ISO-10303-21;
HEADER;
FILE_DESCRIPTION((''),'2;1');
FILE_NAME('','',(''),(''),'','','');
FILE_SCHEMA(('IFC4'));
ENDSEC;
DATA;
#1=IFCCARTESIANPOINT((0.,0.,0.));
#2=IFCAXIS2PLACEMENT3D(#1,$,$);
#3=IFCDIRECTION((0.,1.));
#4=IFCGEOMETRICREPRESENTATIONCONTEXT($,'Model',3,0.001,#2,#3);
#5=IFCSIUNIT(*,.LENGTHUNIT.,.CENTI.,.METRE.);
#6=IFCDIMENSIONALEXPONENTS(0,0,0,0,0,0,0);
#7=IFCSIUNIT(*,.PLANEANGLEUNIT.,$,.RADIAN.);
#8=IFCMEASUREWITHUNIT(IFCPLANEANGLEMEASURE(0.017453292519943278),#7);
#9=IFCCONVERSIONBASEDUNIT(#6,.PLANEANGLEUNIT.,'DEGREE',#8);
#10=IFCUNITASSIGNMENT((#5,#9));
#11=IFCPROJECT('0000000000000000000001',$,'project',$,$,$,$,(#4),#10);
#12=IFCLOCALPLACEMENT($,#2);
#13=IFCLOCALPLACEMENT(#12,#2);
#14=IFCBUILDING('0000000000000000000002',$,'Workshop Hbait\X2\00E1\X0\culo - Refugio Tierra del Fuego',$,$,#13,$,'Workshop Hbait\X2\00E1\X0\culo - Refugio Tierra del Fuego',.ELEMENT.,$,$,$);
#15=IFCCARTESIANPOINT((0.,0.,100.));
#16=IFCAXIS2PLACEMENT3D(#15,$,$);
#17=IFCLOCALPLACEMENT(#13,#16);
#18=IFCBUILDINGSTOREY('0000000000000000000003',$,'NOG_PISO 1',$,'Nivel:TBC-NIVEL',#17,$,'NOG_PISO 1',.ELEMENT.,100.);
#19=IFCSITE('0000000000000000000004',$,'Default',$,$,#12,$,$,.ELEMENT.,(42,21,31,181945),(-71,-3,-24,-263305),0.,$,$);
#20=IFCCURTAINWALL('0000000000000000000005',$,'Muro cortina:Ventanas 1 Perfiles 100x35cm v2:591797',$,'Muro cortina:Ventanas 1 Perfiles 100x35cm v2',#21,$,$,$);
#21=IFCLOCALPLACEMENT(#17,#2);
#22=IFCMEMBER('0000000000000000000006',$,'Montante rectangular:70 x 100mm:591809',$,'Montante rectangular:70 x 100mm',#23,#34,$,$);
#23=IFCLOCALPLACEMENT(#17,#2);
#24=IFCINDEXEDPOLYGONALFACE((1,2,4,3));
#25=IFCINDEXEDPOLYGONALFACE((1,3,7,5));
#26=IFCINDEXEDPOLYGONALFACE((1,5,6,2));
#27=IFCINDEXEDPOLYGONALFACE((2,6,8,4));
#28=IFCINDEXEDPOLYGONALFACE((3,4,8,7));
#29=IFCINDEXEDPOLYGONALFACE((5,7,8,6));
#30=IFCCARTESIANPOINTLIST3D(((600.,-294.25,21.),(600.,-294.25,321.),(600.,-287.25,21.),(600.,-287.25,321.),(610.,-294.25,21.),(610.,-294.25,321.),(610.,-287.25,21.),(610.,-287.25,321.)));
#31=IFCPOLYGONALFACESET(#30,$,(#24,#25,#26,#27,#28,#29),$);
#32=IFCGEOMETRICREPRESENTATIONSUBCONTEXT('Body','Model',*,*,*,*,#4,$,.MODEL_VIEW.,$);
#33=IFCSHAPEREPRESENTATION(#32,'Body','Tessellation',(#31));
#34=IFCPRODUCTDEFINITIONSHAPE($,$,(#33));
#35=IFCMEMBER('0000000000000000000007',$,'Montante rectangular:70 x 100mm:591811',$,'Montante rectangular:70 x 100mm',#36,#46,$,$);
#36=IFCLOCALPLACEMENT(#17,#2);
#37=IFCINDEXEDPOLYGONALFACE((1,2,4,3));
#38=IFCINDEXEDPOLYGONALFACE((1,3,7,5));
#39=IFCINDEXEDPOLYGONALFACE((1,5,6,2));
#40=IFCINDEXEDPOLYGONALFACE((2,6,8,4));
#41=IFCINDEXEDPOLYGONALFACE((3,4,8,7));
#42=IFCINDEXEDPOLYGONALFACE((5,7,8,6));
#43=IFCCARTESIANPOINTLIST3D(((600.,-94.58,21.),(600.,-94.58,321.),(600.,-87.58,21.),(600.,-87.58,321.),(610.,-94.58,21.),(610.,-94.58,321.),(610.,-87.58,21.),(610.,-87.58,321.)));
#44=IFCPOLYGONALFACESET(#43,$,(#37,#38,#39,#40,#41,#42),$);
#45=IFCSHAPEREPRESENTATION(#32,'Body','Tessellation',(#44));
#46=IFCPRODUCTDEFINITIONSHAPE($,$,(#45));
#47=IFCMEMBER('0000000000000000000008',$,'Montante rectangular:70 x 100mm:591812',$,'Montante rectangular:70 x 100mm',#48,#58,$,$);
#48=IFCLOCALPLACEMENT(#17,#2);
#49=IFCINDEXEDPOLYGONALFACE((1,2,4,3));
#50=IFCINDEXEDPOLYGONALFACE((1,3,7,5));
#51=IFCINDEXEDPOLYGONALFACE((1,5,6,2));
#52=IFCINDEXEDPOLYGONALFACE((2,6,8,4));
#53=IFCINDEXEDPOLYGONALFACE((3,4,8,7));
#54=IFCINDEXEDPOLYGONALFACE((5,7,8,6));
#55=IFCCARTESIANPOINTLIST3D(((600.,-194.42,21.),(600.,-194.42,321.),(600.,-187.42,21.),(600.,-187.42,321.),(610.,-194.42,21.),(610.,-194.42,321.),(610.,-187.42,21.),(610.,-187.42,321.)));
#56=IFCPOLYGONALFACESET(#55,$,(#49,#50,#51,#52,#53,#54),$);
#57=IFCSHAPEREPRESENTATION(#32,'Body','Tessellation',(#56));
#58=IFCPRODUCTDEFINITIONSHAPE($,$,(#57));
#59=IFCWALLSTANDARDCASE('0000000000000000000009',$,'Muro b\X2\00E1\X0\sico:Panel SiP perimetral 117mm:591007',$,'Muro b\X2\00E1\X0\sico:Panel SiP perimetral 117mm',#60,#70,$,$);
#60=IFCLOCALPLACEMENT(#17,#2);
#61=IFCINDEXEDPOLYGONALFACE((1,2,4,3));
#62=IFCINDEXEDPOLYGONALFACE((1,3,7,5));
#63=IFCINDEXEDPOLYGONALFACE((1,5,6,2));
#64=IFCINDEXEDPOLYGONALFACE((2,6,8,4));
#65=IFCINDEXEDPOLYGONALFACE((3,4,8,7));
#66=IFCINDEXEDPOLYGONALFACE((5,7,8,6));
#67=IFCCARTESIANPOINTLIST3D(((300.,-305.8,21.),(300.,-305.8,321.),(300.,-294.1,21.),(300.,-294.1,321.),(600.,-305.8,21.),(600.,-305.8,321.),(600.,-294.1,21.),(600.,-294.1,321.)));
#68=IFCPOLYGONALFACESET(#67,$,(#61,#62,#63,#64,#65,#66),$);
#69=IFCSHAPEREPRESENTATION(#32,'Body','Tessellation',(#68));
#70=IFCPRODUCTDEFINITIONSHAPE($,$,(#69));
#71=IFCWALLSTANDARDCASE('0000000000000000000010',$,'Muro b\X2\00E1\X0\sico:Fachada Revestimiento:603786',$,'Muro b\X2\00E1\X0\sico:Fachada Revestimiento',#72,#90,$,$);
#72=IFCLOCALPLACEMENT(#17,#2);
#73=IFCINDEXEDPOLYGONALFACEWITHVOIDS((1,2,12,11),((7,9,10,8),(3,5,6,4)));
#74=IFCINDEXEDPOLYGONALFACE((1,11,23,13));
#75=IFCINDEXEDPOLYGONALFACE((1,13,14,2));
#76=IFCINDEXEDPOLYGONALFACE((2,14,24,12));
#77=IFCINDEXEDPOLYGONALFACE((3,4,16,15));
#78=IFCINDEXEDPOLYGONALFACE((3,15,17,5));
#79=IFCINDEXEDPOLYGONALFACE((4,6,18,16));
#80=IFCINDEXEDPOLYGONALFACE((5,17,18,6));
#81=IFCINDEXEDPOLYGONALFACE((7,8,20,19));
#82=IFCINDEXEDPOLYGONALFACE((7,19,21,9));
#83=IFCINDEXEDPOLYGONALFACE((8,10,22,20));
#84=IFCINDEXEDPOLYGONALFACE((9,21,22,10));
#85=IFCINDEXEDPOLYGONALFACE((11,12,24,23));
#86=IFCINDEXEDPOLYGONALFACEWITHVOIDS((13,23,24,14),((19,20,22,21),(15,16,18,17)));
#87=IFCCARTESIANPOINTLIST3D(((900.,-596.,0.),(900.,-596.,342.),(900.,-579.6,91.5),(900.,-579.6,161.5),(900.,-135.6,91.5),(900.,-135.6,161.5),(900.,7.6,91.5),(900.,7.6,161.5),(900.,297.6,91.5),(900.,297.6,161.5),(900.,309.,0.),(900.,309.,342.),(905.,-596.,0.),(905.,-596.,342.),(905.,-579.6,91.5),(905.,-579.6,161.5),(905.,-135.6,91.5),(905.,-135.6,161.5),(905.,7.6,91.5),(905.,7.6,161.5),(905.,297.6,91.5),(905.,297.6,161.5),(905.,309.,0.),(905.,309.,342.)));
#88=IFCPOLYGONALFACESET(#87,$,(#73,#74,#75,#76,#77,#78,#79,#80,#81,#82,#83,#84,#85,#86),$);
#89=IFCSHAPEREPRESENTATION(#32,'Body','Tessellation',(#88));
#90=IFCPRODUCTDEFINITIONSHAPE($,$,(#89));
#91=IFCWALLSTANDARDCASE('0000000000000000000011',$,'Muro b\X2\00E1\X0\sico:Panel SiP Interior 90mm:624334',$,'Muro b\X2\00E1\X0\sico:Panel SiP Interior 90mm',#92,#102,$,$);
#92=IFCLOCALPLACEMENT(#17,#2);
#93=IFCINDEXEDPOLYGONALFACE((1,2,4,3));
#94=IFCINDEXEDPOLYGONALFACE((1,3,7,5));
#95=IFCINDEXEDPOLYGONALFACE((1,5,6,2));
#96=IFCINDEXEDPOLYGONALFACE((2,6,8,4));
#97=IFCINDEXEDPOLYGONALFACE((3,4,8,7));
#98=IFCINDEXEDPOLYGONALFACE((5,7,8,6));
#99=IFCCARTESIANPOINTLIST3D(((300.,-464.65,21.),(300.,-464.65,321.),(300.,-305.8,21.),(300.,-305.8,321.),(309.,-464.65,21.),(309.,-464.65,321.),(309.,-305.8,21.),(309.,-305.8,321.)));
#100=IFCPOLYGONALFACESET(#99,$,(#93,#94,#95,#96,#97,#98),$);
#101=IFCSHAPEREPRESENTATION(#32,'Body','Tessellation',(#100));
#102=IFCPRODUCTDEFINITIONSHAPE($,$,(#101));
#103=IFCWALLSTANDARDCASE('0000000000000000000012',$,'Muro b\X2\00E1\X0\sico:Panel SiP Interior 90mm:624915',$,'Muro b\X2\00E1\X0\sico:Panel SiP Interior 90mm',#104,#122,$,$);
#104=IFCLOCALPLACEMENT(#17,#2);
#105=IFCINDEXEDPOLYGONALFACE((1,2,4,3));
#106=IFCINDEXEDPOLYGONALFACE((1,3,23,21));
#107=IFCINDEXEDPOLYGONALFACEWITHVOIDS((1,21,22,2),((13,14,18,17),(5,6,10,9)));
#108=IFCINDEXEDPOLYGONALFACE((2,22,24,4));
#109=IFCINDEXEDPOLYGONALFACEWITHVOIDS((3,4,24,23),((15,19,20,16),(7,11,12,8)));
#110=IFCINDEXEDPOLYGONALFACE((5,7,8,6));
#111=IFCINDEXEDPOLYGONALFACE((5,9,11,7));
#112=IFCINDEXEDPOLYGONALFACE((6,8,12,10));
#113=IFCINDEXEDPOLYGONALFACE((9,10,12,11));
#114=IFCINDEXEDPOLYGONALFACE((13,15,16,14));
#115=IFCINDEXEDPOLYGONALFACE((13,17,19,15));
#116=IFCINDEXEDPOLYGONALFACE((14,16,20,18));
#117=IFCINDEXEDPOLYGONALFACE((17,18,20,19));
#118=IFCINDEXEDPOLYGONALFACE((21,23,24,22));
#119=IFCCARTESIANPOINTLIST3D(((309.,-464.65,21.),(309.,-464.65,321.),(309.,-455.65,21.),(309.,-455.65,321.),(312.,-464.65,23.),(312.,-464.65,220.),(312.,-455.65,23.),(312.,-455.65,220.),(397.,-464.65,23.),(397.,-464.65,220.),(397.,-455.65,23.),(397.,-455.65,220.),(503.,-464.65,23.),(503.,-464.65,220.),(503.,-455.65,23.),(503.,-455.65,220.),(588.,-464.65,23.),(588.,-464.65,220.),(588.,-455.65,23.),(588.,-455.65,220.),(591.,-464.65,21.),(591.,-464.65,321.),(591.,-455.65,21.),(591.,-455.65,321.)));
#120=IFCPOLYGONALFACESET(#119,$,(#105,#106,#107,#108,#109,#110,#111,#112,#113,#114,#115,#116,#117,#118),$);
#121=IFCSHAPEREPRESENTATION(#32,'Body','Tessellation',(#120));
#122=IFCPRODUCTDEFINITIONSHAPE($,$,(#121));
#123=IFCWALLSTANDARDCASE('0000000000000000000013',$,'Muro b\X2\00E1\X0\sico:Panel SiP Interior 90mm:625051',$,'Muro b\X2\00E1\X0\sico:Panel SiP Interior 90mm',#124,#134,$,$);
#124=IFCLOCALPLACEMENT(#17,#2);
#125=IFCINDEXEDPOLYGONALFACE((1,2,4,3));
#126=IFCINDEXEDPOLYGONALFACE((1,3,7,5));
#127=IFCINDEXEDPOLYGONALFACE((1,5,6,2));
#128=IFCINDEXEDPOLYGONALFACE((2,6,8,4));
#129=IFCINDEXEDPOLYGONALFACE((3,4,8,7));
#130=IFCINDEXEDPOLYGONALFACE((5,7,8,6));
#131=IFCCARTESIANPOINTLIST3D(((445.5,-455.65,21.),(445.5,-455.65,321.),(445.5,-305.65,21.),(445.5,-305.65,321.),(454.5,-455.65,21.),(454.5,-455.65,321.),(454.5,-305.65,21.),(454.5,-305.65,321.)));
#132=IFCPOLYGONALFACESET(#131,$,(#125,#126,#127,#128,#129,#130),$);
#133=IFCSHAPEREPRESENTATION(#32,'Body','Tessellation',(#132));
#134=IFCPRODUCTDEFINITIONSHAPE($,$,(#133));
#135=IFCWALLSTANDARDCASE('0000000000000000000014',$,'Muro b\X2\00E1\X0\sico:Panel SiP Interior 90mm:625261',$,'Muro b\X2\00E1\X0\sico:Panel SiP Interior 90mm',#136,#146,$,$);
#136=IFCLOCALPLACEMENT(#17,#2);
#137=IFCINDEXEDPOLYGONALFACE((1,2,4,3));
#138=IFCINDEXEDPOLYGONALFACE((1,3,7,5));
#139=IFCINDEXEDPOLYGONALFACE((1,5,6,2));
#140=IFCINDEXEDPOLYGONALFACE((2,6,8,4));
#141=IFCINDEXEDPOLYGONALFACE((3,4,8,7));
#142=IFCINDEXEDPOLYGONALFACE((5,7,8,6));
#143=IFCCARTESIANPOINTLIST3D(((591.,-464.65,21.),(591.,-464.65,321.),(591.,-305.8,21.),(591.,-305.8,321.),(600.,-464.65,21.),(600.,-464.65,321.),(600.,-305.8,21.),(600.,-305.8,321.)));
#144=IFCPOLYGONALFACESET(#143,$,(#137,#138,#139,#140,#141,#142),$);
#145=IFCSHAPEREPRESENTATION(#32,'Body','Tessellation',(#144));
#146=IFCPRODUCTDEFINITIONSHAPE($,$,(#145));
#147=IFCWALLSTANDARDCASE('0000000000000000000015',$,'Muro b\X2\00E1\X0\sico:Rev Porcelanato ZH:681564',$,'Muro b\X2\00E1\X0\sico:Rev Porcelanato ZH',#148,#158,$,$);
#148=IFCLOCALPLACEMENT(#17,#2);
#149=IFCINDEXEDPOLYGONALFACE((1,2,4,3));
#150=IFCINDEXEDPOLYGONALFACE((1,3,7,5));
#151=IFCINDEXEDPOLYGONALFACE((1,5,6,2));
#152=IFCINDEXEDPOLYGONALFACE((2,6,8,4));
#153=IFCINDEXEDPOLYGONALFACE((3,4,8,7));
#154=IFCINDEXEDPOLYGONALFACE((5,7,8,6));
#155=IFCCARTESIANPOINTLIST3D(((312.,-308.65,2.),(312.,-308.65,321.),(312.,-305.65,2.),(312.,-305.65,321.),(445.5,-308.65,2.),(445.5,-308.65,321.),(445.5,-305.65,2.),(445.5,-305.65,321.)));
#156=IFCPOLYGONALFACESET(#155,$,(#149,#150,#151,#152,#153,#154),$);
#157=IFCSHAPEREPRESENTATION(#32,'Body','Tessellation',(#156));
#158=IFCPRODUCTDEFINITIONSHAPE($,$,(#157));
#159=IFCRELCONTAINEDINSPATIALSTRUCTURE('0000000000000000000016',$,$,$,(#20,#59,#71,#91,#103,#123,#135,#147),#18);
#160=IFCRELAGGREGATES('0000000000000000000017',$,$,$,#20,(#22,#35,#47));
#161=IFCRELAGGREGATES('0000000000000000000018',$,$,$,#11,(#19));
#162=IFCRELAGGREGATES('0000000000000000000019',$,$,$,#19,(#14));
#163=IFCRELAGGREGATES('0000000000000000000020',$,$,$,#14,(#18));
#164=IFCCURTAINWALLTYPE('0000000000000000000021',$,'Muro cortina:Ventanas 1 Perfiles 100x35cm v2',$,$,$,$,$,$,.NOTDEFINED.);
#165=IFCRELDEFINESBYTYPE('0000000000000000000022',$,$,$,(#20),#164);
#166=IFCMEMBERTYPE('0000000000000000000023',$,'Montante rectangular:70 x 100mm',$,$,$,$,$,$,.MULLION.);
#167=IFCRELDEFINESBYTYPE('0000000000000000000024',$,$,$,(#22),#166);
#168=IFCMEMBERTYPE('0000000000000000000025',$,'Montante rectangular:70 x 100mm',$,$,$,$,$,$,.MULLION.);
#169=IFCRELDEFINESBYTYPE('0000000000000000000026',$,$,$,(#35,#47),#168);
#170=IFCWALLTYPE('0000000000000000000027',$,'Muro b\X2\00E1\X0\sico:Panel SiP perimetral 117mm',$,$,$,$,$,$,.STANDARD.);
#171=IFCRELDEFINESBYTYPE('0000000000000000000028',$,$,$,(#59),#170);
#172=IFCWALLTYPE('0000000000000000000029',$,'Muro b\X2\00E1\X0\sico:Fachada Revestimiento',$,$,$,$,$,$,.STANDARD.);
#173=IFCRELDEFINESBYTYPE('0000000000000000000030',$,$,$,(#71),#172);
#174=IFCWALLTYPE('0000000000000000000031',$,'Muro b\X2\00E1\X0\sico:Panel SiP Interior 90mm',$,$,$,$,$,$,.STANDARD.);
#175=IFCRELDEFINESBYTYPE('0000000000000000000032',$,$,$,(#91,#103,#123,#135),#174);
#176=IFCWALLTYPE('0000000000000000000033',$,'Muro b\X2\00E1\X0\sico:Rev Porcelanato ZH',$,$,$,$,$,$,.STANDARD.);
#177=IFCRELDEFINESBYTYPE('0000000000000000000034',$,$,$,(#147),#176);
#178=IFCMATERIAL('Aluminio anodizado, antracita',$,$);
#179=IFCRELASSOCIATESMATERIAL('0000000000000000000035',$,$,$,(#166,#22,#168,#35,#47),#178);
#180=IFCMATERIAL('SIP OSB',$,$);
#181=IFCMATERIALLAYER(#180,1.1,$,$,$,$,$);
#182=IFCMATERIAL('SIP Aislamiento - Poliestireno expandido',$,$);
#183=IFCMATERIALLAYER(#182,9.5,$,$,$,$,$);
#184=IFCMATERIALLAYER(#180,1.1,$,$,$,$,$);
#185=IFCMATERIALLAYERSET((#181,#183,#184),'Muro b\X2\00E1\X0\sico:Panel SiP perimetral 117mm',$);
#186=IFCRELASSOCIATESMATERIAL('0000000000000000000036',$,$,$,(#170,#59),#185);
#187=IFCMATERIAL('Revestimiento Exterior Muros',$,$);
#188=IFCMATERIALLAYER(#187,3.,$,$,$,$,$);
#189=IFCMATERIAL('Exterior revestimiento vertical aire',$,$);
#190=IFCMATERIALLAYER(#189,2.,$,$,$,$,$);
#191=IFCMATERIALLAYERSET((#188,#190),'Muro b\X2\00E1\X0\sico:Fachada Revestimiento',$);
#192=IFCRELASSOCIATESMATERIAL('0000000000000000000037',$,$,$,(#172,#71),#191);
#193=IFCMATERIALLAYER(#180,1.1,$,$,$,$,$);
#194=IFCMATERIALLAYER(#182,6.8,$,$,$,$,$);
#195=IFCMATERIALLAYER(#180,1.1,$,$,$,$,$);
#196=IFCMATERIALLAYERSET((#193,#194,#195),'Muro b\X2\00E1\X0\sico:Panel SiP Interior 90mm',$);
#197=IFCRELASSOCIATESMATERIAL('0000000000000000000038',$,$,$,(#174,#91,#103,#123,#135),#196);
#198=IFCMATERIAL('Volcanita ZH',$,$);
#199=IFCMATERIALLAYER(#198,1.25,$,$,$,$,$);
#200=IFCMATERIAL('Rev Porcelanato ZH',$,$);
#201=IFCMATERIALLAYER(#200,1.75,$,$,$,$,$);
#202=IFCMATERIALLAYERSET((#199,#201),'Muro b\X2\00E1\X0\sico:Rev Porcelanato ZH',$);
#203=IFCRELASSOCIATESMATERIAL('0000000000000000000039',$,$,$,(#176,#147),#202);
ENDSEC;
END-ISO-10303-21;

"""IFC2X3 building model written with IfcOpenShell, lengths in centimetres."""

from ifc_helpers import new_model, entity, si_unit, converted_unit, direction, frame, frame_2d, origin, origin_2d_with_axis, place, context, subcontext, project, spatial, rectangle, extrude, source, transform, mapped, material, layer, layer_set, layer_usage, type_object, type_shapes, element, aggregate, save


model = new_model("IFC2X3")

# Units and contexts
model_context = context("Model", 3, precision=0.001, world=origin(), true_north=direction((0.0, 1.0)))
body_context = subcontext(model_context, "Body", "Model", "MODEL_VIEW")
ifc_project = project(units=[si_unit("LENGTHUNIT", "METRE", prefix="CENTI"), converted_unit("PLANEANGLEUNIT", "DEGREE", entity("IfcPlaneAngleMeasure", 0.017453292519943278), si_unit("PLANEANGLEUNIT", "RADIAN"), dimensions=[0, 0, 0, 0, 0, 0, 0])], contexts=[model_context])

# Site, building, storey
site_placement = place(None, origin())
site = spatial("IfcSite", under=ifc_project, at=site_placement, Name="Default", CompositionType="ELEMENT", RefLatitude=(42, 21, 31, 181945), RefLongitude=(-71, -3, -24, -263305), RefElevation=0.0)
building_placement = place(site_placement, origin())
building = spatial("IfcBuilding", under=site, at=building_placement, Name="Workshop Hbaitáculo - Refugio Tierra del Fuego", LongName="Workshop Hbaitáculo - Refugio Tierra del Fuego", CompositionType="ELEMENT")
storey_placement = place(building_placement, frame((0.0, 0.0, 100.0)))
storey = spatial("IfcBuildingStorey", under=building, at=storey_placement, Name="NOG_PISO 1", ObjectType="Nivel:TBC-NIVEL", LongName="NOG_PISO 1", CompositionType="ELEMENT", Elevation=100.0)

# Curtain wall, members
curtain_wall_type = type_object("IfcCurtainWallType", Name="Muro cortina:Ventanas 1 Perfiles 100x35cm v2", PredefinedType="NOTDEFINED")
ifc_material_1 = material(Name="Aluminio anodizado, antracita")
curtain_wall_1_placement = place(storey_placement, frame((0.0, 0.0, -100.0)))
curtain_wall_1 = element("IfcCurtainWall", 1, at=curtain_wall_1_placement, inside=storey, type_object=curtain_wall_type, Name="Muro cortina:Ventanas 1 Perfiles 100x35cm v2:591797", ObjectType="Muro cortina:Ventanas 1 Perfiles 100x35cm v2")
member_type_1 = type_object("IfcMemberType", Name="Montante rectangular:70 x 100mm", PredefinedType="MULLION", material=ifc_material_1)
shared_shape_1 = source(origin(), body_context, "Body", "SweptSolid", [
    extrude(rectangle(XDim=7.0, YDim=10.0, at=origin_2d_with_axis()), frame((-3.5, 0.0, -300.0), z_axis=(0.0, 0.0, 1.0), x_axis=(-1.0, 0.0, 0.0)), (0.0, 0.0, 1.0), 300.0),
])
type_shapes(member_type_1, [shared_shape_1])
member_1_placement = place(curtain_wall_1_placement, frame((605.0, -294.25, 121.0), z_axis=(0.0, 0.0, -1.0), x_axis=(0.0, -1.0, 0.0)))
member_1 = element("IfcMember", 2, at=member_1_placement, type_object=member_type_1, material=ifc_material_1, Name="Montante rectangular:70 x 100mm:591809", ObjectType="Montante rectangular:70 x 100mm", context=body_context, shape_type="MappedRepresentation", body=[
    mapped(shared_shape_1, transform((0.0, 0.0, 0.0), scale=1.0)),
])
member_type_2 = type_object("IfcMemberType", Name="Montante rectangular:70 x 100mm", PredefinedType="MULLION", material=ifc_material_1)
shared_shape_2 = source(origin(), body_context, "Body", "SweptSolid", [
    extrude(rectangle(XDim=7.0, YDim=10.0, at=frame_2d((0.0, 0.0), x_axis=(1.0, 0.0))), frame((0.0, 0.0, -300.0), z_axis=(0.0, 0.0, 1.0), x_axis=(-1.0, 0.0, 0.0)), (0.0, 0.0, 1.0), 300.0),
])
type_shapes(member_type_2, [shared_shape_2])
member_2_placement = place(curtain_wall_1_placement, frame((605.0, -91.08, 121.0), z_axis=(0.0, 0.0, -1.0), x_axis=(0.0, -1.0, 0.0)))
member_2 = element("IfcMember", 3, at=member_2_placement, type_object=member_type_2, material=ifc_material_1, Name="Montante rectangular:70 x 100mm:591811", ObjectType="Montante rectangular:70 x 100mm", context=body_context, shape_type="MappedRepresentation", body=[
    mapped(shared_shape_2, transform((0.0, 0.0, 0.0), scale=1.0)),
])
member_3_placement = place(curtain_wall_1_placement, frame((605.0, -190.92, 121.0), z_axis=(0.0, 0.0, -1.0), x_axis=(0.0, -1.0, 0.0)))
member_3 = element("IfcMember", 4, at=member_3_placement, type_object=member_type_2, material=ifc_material_1, Name="Montante rectangular:70 x 100mm:591812", ObjectType="Montante rectangular:70 x 100mm", context=body_context, shape_type="MappedRepresentation", body=[
    mapped(shared_shape_2, transform((0.0, 0.0, 0.0), scale=1.0)),
])

aggregate(curtain_wall_1, [member_1, member_2, member_3])

# Wall
ifc_material_2 = material(Name="SIP OSB")
ifc_layer_1 = layer(ifc_material_2, 1.1)
ifc_material_3 = material(Name="SIP Aislamiento - Poliestireno expandido")
ifc_layer_2 = layer(ifc_material_3, 9.5)
ifc_layer_3 = layer(ifc_material_2, 1.1)
ifc_layer_set_1 = layer_set([ifc_layer_1, ifc_layer_2, ifc_layer_3], Name="Muro básico:Panel SiP perimetral 117mm")
ifc_layer_usage_1 = layer_usage(ifc_layer_set_1, "AXIS2", "POSITIVE", -5.85)
wall_type_1 = type_object("IfcWallType", Name="Muro básico:Panel SiP perimetral 117mm", PredefinedType="STANDARD", material=ifc_layer_set_1)
wall_1_placement = place(storey_placement, frame((300.0, -299.95, 21.0)))
element("IfcWallStandardCase", 5, at=wall_1_placement, inside=storey, type_object=wall_type_1, material=ifc_layer_usage_1, Name="Muro básico:Panel SiP perimetral 117mm:591007", ObjectType="Muro básico:Panel SiP perimetral 117mm", context=body_context, shape_type="SweptSolid", body=[
    extrude(rectangle(XDim=300.0, YDim=11.7, at=frame_2d((150.0, 0.0), x_axis=(-1.0, 0.0))), origin(), (0.0, 0.0, 1.0), 300.0),
])

# Wall, openings
ifc_material_4 = material(Name="Revestimiento Exterior Muros")
ifc_layer_4 = layer(ifc_material_4, 3.0)
ifc_material_5 = material(Name="Exterior revestimiento vertical aire")
ifc_layer_5 = layer(ifc_material_5, 2.0)
ifc_layer_set_2 = layer_set([ifc_layer_4, ifc_layer_5], Name="Muro básico:Fachada Revestimiento")
ifc_layer_usage_2 = layer_usage(ifc_layer_set_2, "AXIS2", "POSITIVE", -2.5)
wall_type_2 = type_object("IfcWallType", Name="Muro básico:Fachada Revestimiento", PredefinedType="STANDARD", material=ifc_layer_set_2)
wall_2_placement = place(storey_placement, frame((902.5, -596.0, 0.0), z_axis=(0.0, 0.0, 1.0), x_axis=(0.0, 1.0, 0.0)))
wall_2 = element("IfcWallStandardCase", 6, at=wall_2_placement, inside=storey, type_object=wall_type_2, material=ifc_layer_usage_2, Name="Muro básico:Fachada Revestimiento:603786", ObjectType="Muro básico:Fachada Revestimiento", context=body_context, shape_type="SweptSolid", body=[
    extrude(rectangle(XDim=905.0, YDim=5.0, at=frame_2d((452.5, 0.0), x_axis=(-1.0, 0.0))), origin(), (0.0, 0.0, 1.0), 342.0),
])
opening_1_placement = place(wall_2_placement, origin())
element("IfcOpeningElement", 7, at=opening_1_placement, cuts=wall_2, ObjectType="Opening", context=body_context, shape_type="SweptSolid", body=[
    extrude(rectangle(XDim=70.0, YDim=444.0, at=frame_2d((0.0, 0.0), x_axis=(0.0, 1.0))), frame((238.4, 2.5, 126.5), z_axis=(0.0, -1.0, 0.0), x_axis=(-1.0, 0.0, 0.0)), (0.0, 0.0, 1.0), 5.0),
])
opening_2_placement = place(wall_2_placement, origin())
element("IfcOpeningElement", 8, at=opening_2_placement, cuts=wall_2, ObjectType="Opening", context=body_context, shape_type="SweptSolid", body=[
    extrude(rectangle(XDim=70.0, YDim=290.0, at=frame_2d((0.0, 0.0), x_axis=(1.0, 0.0))), frame((748.6, 2.5, 126.5), z_axis=(0.0, -1.0, 0.0), x_axis=(0.0, 0.0, 1.0)), (0.0, 0.0, 1.0), 5.0),
])

# Wall
ifc_layer_6 = layer(ifc_material_2, 1.1)
ifc_layer_7 = layer(ifc_material_3, 6.8)
ifc_layer_8 = layer(ifc_material_2, 1.1)
ifc_layer_set_3 = layer_set([ifc_layer_6, ifc_layer_7, ifc_layer_8], Name="Muro básico:Panel SiP Interior 90mm")
ifc_layer_usage_3 = layer_usage(ifc_layer_set_3, "AXIS2", "NEGATIVE", 4.5)
wall_type_3 = type_object("IfcWallType", Name="Muro básico:Panel SiP Interior 90mm", PredefinedType="STANDARD", material=ifc_layer_set_3)
wall_3_placement = place(storey_placement, frame((304.5, -305.8, 21.0), z_axis=(0.0, 0.0, 1.0), x_axis=(0.0, -1.0, 0.0)))
element("IfcWallStandardCase", 9, at=wall_3_placement, inside=storey, type_object=wall_type_3, material=ifc_layer_usage_3, Name="Muro básico:Panel SiP Interior 90mm:624334", ObjectType="Muro básico:Panel SiP Interior 90mm", context=body_context, shape_type="SweptSolid", body=[
    extrude(rectangle(XDim=158.85, YDim=9.0, at=frame_2d((79.42, 0.0), x_axis=(-1.0, 0.0))), origin(), (0.0, 0.0, 1.0), 300.0),
])

# Wall, openings
ifc_layer_usage_4 = layer_usage(ifc_layer_set_3, "AXIS2", "NEGATIVE", 4.5)
wall_4_placement = place(storey_placement, frame((309.0, -460.15, 21.0)))
wall_4 = element("IfcWallStandardCase", 10, at=wall_4_placement, inside=storey, type_object=wall_type_3, material=ifc_layer_usage_4, Name="Muro básico:Panel SiP Interior 90mm:624915", ObjectType="Muro básico:Panel SiP Interior 90mm", context=body_context, shape_type="SweptSolid", body=[
    extrude(rectangle(XDim=282.0, YDim=9.0, at=frame_2d((141.0, 0.0), x_axis=(-1.0, 0.0))), origin(), (0.0, 0.0, 1.0), 300.0),
])
opening_3_placement = place(wall_4_placement, frame((3.0, -4.5, 2.0)))
element("IfcOpeningElement", 11, at=opening_3_placement, cuts=wall_4, ObjectType="Opening", context=body_context, shape_type="SweptSolid", body=[
    extrude(rectangle(XDim=197.0, YDim=85.0, at=frame_2d((98.5, 42.5), x_axis=(1.0, 0.0))), frame((0.0, 0.0, 0.0), z_axis=(0.0, 1.0, 0.0), x_axis=(0.0, 0.0, 1.0)), (0.0, 0.0, 1.0), 9.0),
])
opening_4_placement = place(wall_4_placement, frame((194.0, -4.5, 2.0)))
element("IfcOpeningElement", 12, at=opening_4_placement, cuts=wall_4, ObjectType="Opening", context=body_context, shape_type="SweptSolid", body=[
    extrude(rectangle(XDim=197.0, YDim=85.0, at=frame_2d((98.5, 42.5), x_axis=(1.0, 0.0))), frame((0.0, 0.0, 0.0), z_axis=(0.0, 1.0, 0.0), x_axis=(0.0, 0.0, 1.0)), (0.0, 0.0, 1.0), 9.0),
])

# Walls
ifc_layer_usage_5 = layer_usage(ifc_layer_set_3, "AXIS2", "NEGATIVE", 4.5)
wall_5_placement = place(storey_placement, frame((450.0, -455.65, 21.0), z_axis=(0.0, 0.0, 1.0), x_axis=(0.0, 1.0, 0.0)))
element("IfcWallStandardCase", 13, at=wall_5_placement, inside=storey, type_object=wall_type_3, material=ifc_layer_usage_5, Name="Muro básico:Panel SiP Interior 90mm:625051", ObjectType="Muro básico:Panel SiP Interior 90mm", context=body_context, shape_type="SweptSolid", body=[
    extrude(rectangle(XDim=150.0, YDim=9.0, at=frame_2d((75.0, 0.0), x_axis=(-1.0, 0.0))), origin(), (0.0, 0.0, 1.0), 300.0),
])
ifc_layer_usage_6 = layer_usage(ifc_layer_set_3, "AXIS2", "POSITIVE", -4.5)
wall_6_placement = place(storey_placement, frame((595.5, -305.8, 21.0), z_axis=(0.0, 0.0, 1.0), x_axis=(0.0, -1.0, 0.0)))
element("IfcWallStandardCase", 14, at=wall_6_placement, inside=storey, type_object=wall_type_3, material=ifc_layer_usage_6, Name="Muro básico:Panel SiP Interior 90mm:625261", ObjectType="Muro básico:Panel SiP Interior 90mm", context=body_context, shape_type="SweptSolid", body=[
    extrude(rectangle(XDim=158.85, YDim=9.0, at=frame_2d((79.43, 0.0), x_axis=(-1.0, 0.0))), origin(), (0.0, 0.0, 1.0), 300.0),
])
ifc_material_6 = material(Name="Volcanita ZH")
ifc_layer_9 = layer(ifc_material_6, 1.25)
ifc_material_7 = material(Name="Rev Porcelanato ZH")
ifc_layer_10 = layer(ifc_material_7, 1.75)
ifc_layer_set_4 = layer_set([ifc_layer_9, ifc_layer_10], Name="Muro básico:Rev Porcelanato ZH")
ifc_layer_usage_7 = layer_usage(ifc_layer_set_4, "AXIS2", "NEGATIVE", 1.5)
wall_type_4 = type_object("IfcWallType", Name="Muro básico:Rev Porcelanato ZH", PredefinedType="STANDARD", material=ifc_layer_set_4)
wall_7_placement = place(storey_placement, frame((312.0, -307.15, 2.0)))
element("IfcWallStandardCase", 15, at=wall_7_placement, inside=storey, type_object=wall_type_4, material=ifc_layer_usage_7, Name="Muro básico:Rev Porcelanato ZH:681564", ObjectType="Muro básico:Rev Porcelanato ZH", context=body_context, shape_type="SweptSolid", body=[
    extrude(rectangle(XDim=133.5, YDim=3.0, at=frame_2d((66.75, 0.0), x_axis=(-1.0, 0.0))), origin(), (0.0, 0.0, 1.0), 319.0),
])

save(model, "model.ifc")
